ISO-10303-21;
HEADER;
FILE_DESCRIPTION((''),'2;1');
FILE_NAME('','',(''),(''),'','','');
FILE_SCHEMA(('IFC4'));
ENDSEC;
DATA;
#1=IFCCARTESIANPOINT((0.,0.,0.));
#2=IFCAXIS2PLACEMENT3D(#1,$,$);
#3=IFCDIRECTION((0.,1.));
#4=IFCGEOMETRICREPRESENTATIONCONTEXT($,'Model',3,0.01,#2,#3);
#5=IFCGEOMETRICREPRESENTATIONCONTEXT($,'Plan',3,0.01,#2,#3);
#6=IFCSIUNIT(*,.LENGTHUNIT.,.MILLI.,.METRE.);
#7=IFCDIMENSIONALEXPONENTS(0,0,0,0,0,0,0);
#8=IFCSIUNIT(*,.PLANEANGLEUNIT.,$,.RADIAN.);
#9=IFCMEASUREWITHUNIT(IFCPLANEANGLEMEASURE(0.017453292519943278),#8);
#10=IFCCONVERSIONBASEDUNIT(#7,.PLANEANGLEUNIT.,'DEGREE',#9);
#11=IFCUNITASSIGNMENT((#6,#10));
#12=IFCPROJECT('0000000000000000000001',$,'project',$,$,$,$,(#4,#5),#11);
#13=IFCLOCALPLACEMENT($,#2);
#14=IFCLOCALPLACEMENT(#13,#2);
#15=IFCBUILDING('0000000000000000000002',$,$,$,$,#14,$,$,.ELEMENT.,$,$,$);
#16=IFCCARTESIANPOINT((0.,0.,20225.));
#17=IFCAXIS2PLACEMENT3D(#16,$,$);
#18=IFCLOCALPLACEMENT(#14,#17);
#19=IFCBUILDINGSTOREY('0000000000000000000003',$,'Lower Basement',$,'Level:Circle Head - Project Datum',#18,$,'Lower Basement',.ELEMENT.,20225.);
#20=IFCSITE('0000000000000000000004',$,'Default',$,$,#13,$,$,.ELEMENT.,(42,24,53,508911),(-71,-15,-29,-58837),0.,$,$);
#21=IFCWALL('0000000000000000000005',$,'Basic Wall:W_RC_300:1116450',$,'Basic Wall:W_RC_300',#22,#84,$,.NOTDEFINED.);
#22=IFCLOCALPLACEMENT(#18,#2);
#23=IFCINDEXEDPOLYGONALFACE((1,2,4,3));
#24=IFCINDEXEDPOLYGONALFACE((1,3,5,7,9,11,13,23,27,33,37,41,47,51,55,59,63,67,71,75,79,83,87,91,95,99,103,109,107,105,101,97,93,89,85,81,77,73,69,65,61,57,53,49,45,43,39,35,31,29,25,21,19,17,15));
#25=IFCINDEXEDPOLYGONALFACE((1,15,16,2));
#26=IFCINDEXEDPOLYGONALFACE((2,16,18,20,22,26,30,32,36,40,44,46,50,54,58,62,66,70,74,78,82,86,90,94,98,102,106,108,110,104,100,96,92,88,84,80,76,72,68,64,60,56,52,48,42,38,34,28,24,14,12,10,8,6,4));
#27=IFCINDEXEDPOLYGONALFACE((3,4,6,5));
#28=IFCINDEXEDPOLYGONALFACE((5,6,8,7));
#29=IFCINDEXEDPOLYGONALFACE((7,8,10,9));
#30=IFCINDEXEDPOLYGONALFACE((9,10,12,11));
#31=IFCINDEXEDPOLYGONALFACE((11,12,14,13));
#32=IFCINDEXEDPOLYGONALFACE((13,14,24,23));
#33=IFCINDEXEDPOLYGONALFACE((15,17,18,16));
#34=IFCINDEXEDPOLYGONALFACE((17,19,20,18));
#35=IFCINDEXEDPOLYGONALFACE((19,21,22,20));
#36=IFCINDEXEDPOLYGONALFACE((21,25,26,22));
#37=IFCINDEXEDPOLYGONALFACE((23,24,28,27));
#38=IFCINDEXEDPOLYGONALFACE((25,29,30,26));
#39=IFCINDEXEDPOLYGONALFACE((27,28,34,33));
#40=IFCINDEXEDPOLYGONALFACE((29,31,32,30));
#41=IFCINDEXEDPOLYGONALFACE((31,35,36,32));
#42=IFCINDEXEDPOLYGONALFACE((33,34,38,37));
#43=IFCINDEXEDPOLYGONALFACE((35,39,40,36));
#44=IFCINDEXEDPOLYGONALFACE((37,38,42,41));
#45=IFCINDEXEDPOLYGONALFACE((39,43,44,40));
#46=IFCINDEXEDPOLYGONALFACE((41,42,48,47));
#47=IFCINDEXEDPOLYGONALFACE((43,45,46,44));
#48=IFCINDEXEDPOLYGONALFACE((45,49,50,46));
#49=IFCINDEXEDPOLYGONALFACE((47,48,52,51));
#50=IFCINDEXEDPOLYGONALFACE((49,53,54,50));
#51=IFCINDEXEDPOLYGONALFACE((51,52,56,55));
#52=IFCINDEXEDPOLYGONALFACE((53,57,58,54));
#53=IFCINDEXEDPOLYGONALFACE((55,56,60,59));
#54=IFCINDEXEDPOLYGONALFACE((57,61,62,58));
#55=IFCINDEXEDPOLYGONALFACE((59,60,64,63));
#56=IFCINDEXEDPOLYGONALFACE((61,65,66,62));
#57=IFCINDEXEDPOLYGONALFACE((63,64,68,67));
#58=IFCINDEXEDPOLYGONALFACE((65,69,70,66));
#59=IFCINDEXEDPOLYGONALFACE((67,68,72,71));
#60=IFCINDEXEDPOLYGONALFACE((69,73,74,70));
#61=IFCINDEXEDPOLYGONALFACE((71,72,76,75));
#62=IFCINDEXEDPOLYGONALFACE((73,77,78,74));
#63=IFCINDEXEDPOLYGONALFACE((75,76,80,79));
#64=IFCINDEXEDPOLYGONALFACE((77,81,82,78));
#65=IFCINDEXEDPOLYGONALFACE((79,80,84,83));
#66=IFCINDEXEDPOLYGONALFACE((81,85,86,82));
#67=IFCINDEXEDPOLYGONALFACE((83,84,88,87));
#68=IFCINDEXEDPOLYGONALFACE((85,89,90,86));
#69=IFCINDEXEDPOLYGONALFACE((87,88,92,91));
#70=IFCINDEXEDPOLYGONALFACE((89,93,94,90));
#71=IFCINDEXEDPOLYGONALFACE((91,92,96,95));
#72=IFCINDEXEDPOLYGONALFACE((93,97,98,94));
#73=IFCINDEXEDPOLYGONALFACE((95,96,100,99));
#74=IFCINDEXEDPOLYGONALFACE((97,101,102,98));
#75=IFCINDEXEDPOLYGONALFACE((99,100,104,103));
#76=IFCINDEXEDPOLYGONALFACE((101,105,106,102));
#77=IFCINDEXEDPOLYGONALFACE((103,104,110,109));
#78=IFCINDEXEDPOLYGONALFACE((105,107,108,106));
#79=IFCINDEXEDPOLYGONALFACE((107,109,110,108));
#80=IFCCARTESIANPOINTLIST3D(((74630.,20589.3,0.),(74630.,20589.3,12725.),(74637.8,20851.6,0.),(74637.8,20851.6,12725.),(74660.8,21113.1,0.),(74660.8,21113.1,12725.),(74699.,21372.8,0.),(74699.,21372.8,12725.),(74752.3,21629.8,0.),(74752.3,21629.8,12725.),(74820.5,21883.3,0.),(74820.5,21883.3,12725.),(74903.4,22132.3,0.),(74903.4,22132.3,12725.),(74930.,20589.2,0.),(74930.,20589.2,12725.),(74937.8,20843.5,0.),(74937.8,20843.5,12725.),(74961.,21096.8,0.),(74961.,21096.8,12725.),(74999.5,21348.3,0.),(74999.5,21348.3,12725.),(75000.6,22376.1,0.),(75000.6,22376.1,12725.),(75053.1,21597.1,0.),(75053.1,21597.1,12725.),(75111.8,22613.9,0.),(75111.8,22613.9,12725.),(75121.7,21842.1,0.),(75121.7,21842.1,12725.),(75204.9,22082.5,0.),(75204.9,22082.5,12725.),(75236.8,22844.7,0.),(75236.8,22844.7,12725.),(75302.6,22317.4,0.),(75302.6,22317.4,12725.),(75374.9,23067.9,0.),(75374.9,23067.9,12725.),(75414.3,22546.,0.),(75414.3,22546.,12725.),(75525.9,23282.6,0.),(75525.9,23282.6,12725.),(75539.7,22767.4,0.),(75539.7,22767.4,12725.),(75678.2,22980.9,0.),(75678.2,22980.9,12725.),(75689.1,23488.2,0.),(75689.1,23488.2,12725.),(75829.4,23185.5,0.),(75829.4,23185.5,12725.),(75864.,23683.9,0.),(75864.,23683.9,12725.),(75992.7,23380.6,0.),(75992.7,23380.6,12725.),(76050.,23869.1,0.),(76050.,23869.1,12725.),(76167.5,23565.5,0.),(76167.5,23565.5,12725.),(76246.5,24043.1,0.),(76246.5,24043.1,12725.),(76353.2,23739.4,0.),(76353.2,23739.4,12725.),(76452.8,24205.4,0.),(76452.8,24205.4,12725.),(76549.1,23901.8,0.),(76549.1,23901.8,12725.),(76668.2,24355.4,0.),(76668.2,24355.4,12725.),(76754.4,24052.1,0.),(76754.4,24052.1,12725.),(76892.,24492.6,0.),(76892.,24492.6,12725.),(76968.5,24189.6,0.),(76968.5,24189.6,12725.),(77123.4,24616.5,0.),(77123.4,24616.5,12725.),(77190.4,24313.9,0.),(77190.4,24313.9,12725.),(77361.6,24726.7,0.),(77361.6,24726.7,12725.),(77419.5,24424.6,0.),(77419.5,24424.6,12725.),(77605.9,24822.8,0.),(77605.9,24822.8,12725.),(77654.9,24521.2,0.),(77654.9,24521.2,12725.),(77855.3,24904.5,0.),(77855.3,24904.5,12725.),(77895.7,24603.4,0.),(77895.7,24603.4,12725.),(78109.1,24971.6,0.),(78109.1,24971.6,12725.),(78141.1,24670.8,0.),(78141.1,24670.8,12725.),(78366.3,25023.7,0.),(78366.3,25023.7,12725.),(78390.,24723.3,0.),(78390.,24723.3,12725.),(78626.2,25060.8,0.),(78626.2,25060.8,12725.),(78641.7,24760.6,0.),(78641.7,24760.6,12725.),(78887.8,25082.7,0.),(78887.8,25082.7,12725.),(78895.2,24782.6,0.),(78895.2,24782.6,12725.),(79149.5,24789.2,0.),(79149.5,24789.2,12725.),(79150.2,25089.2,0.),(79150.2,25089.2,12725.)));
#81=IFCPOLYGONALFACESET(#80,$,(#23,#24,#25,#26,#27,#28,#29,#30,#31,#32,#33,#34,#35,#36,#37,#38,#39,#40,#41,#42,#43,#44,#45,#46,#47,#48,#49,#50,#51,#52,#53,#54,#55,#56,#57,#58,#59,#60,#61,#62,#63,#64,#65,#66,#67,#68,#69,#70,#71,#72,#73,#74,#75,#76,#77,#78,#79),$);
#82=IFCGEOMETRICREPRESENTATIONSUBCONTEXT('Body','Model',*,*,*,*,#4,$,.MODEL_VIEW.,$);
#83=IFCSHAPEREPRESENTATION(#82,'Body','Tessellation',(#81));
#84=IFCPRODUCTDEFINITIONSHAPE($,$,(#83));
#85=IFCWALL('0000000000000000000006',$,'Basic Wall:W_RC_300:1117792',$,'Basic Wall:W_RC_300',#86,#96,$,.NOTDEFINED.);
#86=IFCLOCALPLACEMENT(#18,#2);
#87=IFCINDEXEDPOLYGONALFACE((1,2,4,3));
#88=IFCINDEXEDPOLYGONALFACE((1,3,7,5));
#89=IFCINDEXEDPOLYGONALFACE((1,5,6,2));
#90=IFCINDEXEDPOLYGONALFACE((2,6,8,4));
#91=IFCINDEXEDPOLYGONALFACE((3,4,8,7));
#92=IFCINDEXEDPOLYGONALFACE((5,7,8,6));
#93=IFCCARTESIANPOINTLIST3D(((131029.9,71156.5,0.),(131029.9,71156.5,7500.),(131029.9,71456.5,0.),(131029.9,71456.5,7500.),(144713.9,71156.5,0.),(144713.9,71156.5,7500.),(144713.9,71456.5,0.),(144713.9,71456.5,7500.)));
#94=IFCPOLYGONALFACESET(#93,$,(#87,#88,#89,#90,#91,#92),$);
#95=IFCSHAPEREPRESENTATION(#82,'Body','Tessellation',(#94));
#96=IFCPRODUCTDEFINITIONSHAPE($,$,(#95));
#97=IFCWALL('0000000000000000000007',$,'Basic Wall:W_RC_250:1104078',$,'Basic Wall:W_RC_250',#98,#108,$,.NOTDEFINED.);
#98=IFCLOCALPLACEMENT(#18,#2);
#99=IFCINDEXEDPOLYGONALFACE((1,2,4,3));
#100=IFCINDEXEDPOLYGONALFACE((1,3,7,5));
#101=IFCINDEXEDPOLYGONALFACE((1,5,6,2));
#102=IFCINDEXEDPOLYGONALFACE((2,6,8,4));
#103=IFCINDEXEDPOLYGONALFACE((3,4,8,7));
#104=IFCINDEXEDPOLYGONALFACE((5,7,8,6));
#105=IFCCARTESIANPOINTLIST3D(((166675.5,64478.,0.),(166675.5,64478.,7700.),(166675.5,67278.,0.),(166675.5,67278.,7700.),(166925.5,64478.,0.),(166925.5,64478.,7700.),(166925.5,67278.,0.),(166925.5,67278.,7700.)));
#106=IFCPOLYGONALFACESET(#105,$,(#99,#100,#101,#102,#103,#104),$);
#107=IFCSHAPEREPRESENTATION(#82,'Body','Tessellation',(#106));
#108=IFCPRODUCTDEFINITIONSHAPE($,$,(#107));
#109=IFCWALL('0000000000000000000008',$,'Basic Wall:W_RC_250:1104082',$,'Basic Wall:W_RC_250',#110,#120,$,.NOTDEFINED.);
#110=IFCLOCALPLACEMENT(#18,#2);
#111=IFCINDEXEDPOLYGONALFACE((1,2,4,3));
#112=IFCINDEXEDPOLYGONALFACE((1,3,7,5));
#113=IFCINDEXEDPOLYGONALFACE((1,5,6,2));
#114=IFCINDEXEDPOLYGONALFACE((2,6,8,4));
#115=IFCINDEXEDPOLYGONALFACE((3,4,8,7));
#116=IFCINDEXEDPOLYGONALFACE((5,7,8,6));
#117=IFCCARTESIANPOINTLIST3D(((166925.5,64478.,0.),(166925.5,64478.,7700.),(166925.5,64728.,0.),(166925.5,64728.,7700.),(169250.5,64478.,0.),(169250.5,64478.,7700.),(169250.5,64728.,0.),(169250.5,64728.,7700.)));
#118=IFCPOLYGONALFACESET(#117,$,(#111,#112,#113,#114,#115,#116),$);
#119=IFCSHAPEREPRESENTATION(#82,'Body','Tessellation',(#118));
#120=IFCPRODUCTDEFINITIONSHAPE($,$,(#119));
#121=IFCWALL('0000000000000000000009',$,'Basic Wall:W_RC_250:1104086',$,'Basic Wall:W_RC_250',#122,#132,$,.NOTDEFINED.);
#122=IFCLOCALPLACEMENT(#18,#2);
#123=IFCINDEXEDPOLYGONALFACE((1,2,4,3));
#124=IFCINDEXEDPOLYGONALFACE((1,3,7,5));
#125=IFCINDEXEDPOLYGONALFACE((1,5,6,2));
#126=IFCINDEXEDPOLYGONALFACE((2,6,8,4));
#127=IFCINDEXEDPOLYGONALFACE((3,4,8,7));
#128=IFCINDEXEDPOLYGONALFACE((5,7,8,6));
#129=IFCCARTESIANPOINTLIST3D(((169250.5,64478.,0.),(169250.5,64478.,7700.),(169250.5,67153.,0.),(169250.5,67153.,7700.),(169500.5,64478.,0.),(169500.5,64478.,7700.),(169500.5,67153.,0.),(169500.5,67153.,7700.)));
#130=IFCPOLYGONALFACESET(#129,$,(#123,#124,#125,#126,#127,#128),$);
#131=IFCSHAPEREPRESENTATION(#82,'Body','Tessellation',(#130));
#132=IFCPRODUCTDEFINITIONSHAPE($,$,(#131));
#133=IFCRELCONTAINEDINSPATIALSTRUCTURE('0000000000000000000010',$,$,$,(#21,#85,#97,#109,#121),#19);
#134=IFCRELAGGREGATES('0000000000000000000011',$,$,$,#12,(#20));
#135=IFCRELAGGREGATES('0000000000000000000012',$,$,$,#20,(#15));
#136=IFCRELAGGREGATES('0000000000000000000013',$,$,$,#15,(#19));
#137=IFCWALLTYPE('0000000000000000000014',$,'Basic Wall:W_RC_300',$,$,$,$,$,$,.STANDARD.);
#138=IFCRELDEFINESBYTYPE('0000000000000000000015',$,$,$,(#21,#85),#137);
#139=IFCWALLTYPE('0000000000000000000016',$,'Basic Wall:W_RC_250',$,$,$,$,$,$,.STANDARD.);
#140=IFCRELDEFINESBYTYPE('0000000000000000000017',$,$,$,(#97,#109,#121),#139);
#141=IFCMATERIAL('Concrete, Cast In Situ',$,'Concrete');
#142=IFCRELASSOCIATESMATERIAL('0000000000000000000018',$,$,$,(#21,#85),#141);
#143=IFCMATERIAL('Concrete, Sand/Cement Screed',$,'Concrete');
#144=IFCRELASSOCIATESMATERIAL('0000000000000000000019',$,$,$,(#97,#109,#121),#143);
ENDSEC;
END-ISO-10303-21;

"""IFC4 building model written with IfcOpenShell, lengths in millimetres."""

from ifc_helpers import new_model, entity, si_unit, converted_unit, direction, frame, origin, place, context, subcontext, project, spatial, line, arc, indexed_curve, outline, extrude, material, type_object, element, save


model = new_model("IFC4")

# Units and contexts
model_context = context("Model", 3, precision=0.01, world=origin(), true_north=direction((0.0, 1.0)))
plan_context = context("Plan", 3, precision=0.01, world=origin(), true_north=direction((0.0, 1.0)))
body_context = subcontext(model_context, "Body", "Model", "MODEL_VIEW")
ifc_project = project(units=[si_unit("LENGTHUNIT", "METRE", prefix="MILLI"), converted_unit("PLANEANGLEUNIT", "DEGREE", entity("IfcPlaneAngleMeasure", 0.017453292519943278), si_unit("PLANEANGLEUNIT", "RADIAN"), dimensions=[0, 0, 0, 0, 0, 0, 0])], contexts=[model_context, plan_context])

# Site, building, storey
site_placement = place(None, origin())
site = spatial("IfcSite", under=ifc_project, at=site_placement, Name="Default", CompositionType="ELEMENT", RefLatitude=(42, 24, 53, 508911), RefLongitude=(-71, -15, -29, -58837), RefElevation=0.0)
building_placement = place(site_placement, origin())
building = spatial("IfcBuilding", under=site, at=building_placement, CompositionType="ELEMENT")
storey_placement = place(building_placement, frame((0.0, 0.0, 20225.0)))
storey = spatial("IfcBuildingStorey", under=building, at=storey_placement, Name="Lower Basement", ObjectType="Level:Circle Head - Project Datum", LongName="Lower Basement", CompositionType="ELEMENT", Elevation=20225.0)

# Walls
ifc_material_1 = material(Name="Concrete, Cast In Situ", Category="Concrete")
wall_type_1 = type_object("IfcWallType", Name="Basic Wall:W_RC_300", PredefinedType="STANDARD")
wall_1_placement = place(storey_placement, frame((79150.2, 24939.2, 0.0), z_axis=(0.0, 0.0, 1.0), x_axis=(-1.0, 0.000362, 0.0)))
element("IfcWall", 1, at=wall_1_placement, inside=storey, type_object=wall_type_1, material=ifc_material_1, Name="Basic Wall:W_RC_300:1116450", ObjectType="Basic Wall:W_RC_300", PredefinedType="NOTDEFINED", context=body_context, shape_type="SweptSolid", body=[
    extrude(outline(indexed_curve([(4218.6, 4351.6), (2982.1, 1374.8), (0.6, 150.0), (0.1, -150.0), (3194.1, 1162.5), (4518.6, 4351.6)], segments=[arc(1, 2, 3), line(3, 4), arc(4, 5, 6), line(6, 1)], self_intersect=False)), origin(), (0.0, 0.0, 1.0), 12725.0),
])
wall_2_placement = place(storey_placement, frame((144713.9, 71306.5, 0.0), z_axis=(0.0, 0.0, 1.0), x_axis=(-1.0, 0.0, 0.0)))
element("IfcWall", 2, at=wall_2_placement, inside=storey, type_object=wall_type_1, material=ifc_material_1, Name="Basic Wall:W_RC_300:1117792", ObjectType="Basic Wall:W_RC_300", PredefinedType="NOTDEFINED", context=body_context, shape_type="SweptSolid", body=[
    extrude(outline(indexed_curve([(13684.1, 150.0), (0.0, 150.0), (0.0, -150.0), (13684.1, -150.0), (13684.1, 150.0)], self_intersect=False)), origin(), (0.0, 0.0, 1.0), 7500.0),
])
ifc_material_2 = material(Name="Concrete, Sand/Cement Screed", Category="Concrete")
wall_type_2 = type_object("IfcWallType", Name="Basic Wall:W_RC_250", PredefinedType="STANDARD")
wall_3_placement = place(storey_placement, frame((166800.5, 64478.0, 0.0), z_axis=(0.0, 0.0, 1.0), x_axis=(0.0, 1.0, 0.0)))
element("IfcWall", 3, at=wall_3_placement, inside=storey, type_object=wall_type_2, material=ifc_material_2, Name="Basic Wall:W_RC_250:1104078", ObjectType="Basic Wall:W_RC_250", PredefinedType="NOTDEFINED", context=body_context, shape_type="SweptSolid", body=[
    extrude(outline(indexed_curve([(2800.0, 125.0), (0.0, 125.0), (0.0, -125.0), (2800.0, -125.0), (2800.0, 125.0)], self_intersect=False)), origin(), (0.0, 0.0, 1.0), 7700.0),
])
wall_4_placement = place(storey_placement, frame((169250.5, 64603.0, 0.0), z_axis=(0.0, 0.0, 1.0), x_axis=(-1.0, 0.0, 0.0)))
element("IfcWall", 4, at=wall_4_placement, inside=storey, type_object=wall_type_2, material=ifc_material_2, Name="Basic Wall:W_RC_250:1104082", ObjectType="Basic Wall:W_RC_250", PredefinedType="NOTDEFINED", context=body_context, shape_type="SweptSolid", body=[
    extrude(outline(indexed_curve([(2325.0, 125.0), (0.0, 125.0), (0.0, -125.0), (2325.0, -125.0), (2325.0, 125.0)], self_intersect=False)), origin(), (0.0, 0.0, 1.0), 7700.0),
])
wall_5_placement = place(storey_placement, frame((169375.5, 67153.0, 0.0), z_axis=(0.0, 0.0, 1.0), x_axis=(0.0, -1.0, 0.0)))
element("IfcWall", 5, at=wall_5_placement, inside=storey, type_object=wall_type_2, material=ifc_material_2, Name="Basic Wall:W_RC_250:1104086", ObjectType="Basic Wall:W_RC_250", PredefinedType="NOTDEFINED", context=body_context, shape_type="SweptSolid", body=[
    extrude(outline(indexed_curve([(2675.0, 125.0), (0.0, 125.0), (0.0, -125.0), (2675.0, -125.0), (2675.0, 125.0)], self_intersect=False)), origin(), (0.0, 0.0, 1.0), 7700.0),
])

save(model, "model.ifc")
